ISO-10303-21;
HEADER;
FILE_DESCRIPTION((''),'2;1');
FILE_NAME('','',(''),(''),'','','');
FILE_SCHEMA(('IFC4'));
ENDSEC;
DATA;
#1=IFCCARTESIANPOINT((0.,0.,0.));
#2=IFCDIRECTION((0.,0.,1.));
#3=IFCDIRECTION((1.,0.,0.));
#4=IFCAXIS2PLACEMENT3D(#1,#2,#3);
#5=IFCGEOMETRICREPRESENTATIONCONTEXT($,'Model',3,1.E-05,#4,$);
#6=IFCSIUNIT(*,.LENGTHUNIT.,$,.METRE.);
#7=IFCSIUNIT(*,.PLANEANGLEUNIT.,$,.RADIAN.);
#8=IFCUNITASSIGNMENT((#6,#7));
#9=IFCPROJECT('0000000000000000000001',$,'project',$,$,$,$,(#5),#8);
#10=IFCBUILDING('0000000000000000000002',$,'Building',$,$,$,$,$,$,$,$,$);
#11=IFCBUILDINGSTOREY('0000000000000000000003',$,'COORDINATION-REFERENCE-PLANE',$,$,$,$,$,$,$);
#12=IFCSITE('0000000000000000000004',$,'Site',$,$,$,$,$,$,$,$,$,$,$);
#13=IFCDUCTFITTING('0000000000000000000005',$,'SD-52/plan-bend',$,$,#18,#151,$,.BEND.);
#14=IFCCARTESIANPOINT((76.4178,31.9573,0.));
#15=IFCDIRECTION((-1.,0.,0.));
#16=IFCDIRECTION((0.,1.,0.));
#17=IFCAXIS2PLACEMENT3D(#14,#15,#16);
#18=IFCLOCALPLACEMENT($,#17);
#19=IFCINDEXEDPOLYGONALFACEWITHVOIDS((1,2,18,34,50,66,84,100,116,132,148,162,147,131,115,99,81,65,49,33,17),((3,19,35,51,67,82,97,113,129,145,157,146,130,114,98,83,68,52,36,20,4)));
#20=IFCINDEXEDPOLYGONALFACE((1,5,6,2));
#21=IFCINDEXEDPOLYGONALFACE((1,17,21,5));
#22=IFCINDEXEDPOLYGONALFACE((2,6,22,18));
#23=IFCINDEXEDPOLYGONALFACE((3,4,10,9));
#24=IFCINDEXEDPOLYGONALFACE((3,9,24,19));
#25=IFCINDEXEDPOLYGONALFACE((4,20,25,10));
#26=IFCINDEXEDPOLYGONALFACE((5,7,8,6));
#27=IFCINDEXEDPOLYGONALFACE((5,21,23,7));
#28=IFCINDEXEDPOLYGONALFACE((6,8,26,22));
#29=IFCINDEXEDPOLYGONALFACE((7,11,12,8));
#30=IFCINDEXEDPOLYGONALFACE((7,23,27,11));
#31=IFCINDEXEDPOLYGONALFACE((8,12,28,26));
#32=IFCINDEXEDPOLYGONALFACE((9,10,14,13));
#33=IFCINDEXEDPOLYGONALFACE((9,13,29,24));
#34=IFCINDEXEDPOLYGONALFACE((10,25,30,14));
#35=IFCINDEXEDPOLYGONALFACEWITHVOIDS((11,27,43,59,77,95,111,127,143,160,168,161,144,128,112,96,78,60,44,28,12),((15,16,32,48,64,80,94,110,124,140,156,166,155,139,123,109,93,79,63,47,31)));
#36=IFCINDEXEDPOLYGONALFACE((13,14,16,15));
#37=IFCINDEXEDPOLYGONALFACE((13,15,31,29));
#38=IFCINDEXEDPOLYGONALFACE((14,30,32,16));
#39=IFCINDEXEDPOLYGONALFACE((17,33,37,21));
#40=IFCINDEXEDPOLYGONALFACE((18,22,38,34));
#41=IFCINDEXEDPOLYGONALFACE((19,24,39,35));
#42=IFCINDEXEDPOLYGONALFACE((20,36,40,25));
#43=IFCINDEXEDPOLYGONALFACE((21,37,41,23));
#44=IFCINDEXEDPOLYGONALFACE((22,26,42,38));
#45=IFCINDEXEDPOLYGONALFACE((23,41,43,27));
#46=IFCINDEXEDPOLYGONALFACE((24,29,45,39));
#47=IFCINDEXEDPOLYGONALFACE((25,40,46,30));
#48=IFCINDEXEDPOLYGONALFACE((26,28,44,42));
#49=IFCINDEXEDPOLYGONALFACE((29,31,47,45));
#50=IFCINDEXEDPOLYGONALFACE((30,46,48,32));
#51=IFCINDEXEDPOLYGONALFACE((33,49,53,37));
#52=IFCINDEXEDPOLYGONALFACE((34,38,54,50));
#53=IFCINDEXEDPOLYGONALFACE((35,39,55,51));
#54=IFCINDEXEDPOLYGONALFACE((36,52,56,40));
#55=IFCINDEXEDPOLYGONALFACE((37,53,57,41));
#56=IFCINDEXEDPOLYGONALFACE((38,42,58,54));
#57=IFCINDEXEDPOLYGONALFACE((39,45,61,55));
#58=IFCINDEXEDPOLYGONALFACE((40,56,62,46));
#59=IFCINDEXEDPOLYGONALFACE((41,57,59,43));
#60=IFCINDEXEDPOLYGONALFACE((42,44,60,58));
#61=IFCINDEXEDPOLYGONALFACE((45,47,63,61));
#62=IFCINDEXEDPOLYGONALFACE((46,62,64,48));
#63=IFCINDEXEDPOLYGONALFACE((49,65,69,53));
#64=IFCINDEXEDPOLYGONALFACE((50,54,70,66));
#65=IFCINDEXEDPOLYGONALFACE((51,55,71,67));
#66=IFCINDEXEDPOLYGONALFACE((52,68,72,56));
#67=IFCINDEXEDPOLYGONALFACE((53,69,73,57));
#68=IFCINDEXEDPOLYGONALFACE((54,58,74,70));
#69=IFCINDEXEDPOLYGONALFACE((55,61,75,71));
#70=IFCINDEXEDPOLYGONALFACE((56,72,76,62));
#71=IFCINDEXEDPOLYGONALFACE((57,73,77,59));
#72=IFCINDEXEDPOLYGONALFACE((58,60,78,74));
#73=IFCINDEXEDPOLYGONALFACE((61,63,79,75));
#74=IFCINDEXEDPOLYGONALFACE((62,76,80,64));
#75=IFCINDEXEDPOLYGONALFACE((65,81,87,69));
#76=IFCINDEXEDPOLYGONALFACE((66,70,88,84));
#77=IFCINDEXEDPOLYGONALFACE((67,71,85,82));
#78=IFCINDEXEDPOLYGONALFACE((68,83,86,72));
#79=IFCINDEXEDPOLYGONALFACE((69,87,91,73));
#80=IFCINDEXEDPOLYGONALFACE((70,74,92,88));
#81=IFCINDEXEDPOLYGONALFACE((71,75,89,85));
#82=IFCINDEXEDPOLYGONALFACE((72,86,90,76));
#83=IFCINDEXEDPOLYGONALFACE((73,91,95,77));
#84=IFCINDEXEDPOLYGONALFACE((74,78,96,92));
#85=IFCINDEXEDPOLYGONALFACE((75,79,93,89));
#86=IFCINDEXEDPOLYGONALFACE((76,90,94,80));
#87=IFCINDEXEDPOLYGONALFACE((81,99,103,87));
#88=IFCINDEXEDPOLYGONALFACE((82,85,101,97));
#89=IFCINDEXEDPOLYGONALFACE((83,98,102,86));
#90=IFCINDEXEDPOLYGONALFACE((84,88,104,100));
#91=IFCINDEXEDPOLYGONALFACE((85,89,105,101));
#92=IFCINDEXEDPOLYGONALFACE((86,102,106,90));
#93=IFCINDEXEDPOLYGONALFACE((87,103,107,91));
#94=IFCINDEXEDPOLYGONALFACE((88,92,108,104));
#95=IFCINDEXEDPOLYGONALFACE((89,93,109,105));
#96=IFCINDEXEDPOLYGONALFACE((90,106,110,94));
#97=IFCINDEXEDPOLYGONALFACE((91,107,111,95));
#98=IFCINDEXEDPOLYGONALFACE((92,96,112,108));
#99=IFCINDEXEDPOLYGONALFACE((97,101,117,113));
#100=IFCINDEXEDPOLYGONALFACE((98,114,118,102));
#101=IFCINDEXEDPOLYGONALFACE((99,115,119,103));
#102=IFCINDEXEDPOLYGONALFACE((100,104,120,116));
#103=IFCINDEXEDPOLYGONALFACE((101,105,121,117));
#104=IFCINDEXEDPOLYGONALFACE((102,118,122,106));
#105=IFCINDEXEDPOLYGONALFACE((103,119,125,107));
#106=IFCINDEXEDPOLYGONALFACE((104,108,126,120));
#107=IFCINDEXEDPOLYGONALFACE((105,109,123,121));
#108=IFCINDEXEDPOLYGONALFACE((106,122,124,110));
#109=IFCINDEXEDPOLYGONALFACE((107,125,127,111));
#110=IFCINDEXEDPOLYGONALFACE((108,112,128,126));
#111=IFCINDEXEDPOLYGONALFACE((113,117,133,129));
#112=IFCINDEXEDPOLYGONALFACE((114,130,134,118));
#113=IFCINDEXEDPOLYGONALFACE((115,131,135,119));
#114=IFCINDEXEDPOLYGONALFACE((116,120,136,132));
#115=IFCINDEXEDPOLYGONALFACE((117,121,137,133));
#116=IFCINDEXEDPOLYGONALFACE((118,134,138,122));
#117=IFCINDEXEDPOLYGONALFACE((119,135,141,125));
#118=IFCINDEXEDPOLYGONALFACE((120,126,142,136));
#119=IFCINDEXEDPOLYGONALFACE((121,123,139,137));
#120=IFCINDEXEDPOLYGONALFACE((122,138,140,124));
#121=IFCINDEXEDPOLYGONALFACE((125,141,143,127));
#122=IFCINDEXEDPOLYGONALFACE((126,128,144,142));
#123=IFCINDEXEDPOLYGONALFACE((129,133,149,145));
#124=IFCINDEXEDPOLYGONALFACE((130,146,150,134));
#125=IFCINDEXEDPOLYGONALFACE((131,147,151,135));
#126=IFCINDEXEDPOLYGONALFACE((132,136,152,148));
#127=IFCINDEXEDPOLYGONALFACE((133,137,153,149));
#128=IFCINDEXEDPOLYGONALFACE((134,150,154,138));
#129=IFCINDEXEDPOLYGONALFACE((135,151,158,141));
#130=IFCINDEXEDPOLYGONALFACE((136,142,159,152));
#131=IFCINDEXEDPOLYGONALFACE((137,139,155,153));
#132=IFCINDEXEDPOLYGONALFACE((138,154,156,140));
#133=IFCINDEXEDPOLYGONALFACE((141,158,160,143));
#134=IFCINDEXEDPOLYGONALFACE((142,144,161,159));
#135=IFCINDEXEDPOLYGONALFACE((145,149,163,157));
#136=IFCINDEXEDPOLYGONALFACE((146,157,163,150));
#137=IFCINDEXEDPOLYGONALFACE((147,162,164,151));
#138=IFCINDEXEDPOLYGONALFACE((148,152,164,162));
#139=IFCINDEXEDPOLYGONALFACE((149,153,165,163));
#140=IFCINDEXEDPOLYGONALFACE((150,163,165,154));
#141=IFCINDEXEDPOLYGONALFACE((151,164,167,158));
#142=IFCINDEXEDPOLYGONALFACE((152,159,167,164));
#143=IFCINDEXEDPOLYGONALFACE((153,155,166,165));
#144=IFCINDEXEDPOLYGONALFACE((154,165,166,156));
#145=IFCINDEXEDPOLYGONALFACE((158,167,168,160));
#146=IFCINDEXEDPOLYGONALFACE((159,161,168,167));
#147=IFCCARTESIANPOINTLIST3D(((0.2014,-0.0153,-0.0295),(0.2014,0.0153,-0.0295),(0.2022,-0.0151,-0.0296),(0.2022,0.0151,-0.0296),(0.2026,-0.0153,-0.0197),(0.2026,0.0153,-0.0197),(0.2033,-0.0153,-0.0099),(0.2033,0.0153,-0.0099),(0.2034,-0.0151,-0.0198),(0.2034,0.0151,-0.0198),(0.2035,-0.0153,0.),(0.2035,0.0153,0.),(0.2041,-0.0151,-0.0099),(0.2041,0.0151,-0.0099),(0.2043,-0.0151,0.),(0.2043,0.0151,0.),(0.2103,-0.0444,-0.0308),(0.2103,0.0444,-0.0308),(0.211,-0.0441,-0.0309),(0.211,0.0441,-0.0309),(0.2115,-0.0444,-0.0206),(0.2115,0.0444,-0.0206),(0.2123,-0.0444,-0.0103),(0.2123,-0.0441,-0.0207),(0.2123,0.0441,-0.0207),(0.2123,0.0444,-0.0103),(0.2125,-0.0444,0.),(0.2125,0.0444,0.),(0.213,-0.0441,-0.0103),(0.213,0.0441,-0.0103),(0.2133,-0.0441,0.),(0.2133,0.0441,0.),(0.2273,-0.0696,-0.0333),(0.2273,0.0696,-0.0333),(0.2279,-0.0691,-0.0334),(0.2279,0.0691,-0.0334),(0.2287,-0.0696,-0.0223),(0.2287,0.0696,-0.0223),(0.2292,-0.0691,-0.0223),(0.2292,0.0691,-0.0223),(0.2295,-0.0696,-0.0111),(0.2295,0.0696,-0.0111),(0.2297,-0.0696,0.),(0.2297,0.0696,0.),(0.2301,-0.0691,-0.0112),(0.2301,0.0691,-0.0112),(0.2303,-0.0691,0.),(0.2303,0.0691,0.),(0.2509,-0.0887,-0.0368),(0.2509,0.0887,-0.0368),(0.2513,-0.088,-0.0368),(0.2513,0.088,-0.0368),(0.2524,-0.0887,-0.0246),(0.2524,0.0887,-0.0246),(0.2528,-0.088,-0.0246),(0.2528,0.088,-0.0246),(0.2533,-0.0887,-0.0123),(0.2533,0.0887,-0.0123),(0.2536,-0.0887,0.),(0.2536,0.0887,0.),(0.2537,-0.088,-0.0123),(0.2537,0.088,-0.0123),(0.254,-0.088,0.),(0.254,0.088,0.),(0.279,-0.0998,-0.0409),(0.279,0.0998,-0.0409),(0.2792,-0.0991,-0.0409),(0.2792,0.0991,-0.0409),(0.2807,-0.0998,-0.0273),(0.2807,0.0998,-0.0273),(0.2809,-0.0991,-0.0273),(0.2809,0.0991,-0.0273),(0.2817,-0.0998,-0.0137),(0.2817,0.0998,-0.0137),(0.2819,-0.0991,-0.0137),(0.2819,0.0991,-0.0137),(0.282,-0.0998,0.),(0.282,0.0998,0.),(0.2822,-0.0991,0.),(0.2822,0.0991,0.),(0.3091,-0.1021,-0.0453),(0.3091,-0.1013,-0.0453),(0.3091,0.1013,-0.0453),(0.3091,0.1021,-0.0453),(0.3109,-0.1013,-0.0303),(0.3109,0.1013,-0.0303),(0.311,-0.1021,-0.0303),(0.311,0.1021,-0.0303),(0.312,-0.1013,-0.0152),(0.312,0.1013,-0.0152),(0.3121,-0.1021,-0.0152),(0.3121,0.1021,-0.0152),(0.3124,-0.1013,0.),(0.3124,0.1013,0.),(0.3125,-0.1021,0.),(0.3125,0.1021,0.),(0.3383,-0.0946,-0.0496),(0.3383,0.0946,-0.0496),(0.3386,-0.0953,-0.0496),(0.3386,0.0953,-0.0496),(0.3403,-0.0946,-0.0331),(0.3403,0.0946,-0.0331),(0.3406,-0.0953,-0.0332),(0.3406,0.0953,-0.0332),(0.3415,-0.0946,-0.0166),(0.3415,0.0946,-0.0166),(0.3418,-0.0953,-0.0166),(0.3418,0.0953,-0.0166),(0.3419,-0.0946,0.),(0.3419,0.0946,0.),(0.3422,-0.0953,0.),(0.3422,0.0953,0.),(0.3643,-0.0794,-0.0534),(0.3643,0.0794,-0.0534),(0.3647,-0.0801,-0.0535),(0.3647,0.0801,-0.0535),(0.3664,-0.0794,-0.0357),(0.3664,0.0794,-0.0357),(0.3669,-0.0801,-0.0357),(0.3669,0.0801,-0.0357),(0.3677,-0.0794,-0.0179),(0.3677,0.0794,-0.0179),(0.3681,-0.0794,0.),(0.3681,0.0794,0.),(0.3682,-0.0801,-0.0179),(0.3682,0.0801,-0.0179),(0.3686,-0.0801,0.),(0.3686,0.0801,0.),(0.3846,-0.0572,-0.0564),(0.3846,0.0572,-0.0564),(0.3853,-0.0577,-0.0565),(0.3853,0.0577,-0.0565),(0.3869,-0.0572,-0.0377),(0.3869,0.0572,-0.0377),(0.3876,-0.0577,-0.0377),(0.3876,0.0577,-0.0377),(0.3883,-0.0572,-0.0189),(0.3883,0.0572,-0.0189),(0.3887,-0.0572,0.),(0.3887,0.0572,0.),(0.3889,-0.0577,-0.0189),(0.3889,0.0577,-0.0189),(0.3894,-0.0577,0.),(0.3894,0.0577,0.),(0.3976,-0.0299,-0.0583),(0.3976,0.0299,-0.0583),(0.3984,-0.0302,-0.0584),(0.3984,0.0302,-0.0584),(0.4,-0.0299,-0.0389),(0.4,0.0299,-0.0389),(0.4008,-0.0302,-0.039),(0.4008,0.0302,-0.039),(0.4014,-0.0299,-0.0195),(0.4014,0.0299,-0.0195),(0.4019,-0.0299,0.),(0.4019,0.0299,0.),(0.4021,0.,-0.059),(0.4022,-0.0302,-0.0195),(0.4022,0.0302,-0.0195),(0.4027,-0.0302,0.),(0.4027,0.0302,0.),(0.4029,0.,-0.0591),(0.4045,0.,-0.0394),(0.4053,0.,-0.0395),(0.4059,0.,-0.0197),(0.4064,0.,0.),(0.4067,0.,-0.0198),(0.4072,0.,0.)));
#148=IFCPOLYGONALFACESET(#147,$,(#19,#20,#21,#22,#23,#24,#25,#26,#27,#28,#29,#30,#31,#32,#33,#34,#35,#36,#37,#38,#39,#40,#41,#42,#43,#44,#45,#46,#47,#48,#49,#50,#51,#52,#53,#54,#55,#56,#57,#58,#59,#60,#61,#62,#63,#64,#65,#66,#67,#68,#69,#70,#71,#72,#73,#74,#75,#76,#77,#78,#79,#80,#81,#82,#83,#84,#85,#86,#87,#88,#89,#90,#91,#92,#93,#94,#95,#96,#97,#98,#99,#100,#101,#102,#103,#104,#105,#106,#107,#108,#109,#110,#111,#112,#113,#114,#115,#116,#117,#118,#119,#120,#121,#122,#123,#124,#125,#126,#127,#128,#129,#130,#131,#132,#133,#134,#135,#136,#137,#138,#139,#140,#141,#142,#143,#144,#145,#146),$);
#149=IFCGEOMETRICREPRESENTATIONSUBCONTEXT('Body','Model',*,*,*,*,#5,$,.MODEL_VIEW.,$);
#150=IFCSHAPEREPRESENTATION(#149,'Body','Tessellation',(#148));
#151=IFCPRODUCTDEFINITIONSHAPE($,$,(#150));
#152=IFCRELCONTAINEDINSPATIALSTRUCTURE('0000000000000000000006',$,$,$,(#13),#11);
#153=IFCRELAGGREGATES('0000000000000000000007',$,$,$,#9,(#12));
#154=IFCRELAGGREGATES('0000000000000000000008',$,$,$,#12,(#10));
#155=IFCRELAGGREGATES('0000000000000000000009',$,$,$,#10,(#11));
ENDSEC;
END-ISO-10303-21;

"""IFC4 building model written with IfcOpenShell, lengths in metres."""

from ifc_helpers import new_model, entity, si_unit, frame, origin_with_axes, place, context, subcontext, project, spatial, element, save


model = new_model("IFC4")

# Units and contexts
model_context = context("Model", 3, precision=1e-05, world=origin_with_axes())
body_context_1 = subcontext(model_context, "Body", "Model", "MODEL_VIEW")
ifc_project = project(units=[si_unit("LENGTHUNIT", "METRE"), si_unit("PLANEANGLEUNIT", "RADIAN")], contexts=[model_context])

# Site, building, storey
site = spatial("IfcSite", under=ifc_project, Name="Site")
building = spatial("IfcBuilding", under=site, Name="Building")
storey = spatial("IfcBuildingStorey", under=building, Name="COORDINATION-REFERENCE-PLANE")

# Duct fitting
duct_fitting_1_placement = place(None, frame((76.4178, 31.9573, 0.0), z_axis=(-1.0, 0.0, 0.0), x_axis=(0.0, 1.0, 0.0)))
element("IfcDuctFitting", 1, at=duct_fitting_1_placement, inside=storey, Name="SD-52/plan-bend", PredefinedType="BEND", context=body_context_1, shape_type="SweptSolid", body=[
    entity("IfcRevolvedAreaSolid", entity("IfcCircleHollowProfileDef", "AREA", None, entity("IfcAxis2Placement2D", entity("IfcCartesianPoint", [0.3048, 0.0])), 0.1024, 0.0008), entity("IfcAxis2Placement3D", entity("IfcCartesianPoint", [0.0, 0.0, 0.0]), entity("IfcDirection", [0.0, 0.0, 1.0]), entity("IfcDirection", [1.0, 0.0, 0.0])), entity("IfcAxis1Placement", entity("IfcCartesianPoint", [0.0, 0.0, 0.0]), entity("IfcDirection", [0.0, 1.0, 0.0])), 0.145576),
])

save(model, "model.ifc")
